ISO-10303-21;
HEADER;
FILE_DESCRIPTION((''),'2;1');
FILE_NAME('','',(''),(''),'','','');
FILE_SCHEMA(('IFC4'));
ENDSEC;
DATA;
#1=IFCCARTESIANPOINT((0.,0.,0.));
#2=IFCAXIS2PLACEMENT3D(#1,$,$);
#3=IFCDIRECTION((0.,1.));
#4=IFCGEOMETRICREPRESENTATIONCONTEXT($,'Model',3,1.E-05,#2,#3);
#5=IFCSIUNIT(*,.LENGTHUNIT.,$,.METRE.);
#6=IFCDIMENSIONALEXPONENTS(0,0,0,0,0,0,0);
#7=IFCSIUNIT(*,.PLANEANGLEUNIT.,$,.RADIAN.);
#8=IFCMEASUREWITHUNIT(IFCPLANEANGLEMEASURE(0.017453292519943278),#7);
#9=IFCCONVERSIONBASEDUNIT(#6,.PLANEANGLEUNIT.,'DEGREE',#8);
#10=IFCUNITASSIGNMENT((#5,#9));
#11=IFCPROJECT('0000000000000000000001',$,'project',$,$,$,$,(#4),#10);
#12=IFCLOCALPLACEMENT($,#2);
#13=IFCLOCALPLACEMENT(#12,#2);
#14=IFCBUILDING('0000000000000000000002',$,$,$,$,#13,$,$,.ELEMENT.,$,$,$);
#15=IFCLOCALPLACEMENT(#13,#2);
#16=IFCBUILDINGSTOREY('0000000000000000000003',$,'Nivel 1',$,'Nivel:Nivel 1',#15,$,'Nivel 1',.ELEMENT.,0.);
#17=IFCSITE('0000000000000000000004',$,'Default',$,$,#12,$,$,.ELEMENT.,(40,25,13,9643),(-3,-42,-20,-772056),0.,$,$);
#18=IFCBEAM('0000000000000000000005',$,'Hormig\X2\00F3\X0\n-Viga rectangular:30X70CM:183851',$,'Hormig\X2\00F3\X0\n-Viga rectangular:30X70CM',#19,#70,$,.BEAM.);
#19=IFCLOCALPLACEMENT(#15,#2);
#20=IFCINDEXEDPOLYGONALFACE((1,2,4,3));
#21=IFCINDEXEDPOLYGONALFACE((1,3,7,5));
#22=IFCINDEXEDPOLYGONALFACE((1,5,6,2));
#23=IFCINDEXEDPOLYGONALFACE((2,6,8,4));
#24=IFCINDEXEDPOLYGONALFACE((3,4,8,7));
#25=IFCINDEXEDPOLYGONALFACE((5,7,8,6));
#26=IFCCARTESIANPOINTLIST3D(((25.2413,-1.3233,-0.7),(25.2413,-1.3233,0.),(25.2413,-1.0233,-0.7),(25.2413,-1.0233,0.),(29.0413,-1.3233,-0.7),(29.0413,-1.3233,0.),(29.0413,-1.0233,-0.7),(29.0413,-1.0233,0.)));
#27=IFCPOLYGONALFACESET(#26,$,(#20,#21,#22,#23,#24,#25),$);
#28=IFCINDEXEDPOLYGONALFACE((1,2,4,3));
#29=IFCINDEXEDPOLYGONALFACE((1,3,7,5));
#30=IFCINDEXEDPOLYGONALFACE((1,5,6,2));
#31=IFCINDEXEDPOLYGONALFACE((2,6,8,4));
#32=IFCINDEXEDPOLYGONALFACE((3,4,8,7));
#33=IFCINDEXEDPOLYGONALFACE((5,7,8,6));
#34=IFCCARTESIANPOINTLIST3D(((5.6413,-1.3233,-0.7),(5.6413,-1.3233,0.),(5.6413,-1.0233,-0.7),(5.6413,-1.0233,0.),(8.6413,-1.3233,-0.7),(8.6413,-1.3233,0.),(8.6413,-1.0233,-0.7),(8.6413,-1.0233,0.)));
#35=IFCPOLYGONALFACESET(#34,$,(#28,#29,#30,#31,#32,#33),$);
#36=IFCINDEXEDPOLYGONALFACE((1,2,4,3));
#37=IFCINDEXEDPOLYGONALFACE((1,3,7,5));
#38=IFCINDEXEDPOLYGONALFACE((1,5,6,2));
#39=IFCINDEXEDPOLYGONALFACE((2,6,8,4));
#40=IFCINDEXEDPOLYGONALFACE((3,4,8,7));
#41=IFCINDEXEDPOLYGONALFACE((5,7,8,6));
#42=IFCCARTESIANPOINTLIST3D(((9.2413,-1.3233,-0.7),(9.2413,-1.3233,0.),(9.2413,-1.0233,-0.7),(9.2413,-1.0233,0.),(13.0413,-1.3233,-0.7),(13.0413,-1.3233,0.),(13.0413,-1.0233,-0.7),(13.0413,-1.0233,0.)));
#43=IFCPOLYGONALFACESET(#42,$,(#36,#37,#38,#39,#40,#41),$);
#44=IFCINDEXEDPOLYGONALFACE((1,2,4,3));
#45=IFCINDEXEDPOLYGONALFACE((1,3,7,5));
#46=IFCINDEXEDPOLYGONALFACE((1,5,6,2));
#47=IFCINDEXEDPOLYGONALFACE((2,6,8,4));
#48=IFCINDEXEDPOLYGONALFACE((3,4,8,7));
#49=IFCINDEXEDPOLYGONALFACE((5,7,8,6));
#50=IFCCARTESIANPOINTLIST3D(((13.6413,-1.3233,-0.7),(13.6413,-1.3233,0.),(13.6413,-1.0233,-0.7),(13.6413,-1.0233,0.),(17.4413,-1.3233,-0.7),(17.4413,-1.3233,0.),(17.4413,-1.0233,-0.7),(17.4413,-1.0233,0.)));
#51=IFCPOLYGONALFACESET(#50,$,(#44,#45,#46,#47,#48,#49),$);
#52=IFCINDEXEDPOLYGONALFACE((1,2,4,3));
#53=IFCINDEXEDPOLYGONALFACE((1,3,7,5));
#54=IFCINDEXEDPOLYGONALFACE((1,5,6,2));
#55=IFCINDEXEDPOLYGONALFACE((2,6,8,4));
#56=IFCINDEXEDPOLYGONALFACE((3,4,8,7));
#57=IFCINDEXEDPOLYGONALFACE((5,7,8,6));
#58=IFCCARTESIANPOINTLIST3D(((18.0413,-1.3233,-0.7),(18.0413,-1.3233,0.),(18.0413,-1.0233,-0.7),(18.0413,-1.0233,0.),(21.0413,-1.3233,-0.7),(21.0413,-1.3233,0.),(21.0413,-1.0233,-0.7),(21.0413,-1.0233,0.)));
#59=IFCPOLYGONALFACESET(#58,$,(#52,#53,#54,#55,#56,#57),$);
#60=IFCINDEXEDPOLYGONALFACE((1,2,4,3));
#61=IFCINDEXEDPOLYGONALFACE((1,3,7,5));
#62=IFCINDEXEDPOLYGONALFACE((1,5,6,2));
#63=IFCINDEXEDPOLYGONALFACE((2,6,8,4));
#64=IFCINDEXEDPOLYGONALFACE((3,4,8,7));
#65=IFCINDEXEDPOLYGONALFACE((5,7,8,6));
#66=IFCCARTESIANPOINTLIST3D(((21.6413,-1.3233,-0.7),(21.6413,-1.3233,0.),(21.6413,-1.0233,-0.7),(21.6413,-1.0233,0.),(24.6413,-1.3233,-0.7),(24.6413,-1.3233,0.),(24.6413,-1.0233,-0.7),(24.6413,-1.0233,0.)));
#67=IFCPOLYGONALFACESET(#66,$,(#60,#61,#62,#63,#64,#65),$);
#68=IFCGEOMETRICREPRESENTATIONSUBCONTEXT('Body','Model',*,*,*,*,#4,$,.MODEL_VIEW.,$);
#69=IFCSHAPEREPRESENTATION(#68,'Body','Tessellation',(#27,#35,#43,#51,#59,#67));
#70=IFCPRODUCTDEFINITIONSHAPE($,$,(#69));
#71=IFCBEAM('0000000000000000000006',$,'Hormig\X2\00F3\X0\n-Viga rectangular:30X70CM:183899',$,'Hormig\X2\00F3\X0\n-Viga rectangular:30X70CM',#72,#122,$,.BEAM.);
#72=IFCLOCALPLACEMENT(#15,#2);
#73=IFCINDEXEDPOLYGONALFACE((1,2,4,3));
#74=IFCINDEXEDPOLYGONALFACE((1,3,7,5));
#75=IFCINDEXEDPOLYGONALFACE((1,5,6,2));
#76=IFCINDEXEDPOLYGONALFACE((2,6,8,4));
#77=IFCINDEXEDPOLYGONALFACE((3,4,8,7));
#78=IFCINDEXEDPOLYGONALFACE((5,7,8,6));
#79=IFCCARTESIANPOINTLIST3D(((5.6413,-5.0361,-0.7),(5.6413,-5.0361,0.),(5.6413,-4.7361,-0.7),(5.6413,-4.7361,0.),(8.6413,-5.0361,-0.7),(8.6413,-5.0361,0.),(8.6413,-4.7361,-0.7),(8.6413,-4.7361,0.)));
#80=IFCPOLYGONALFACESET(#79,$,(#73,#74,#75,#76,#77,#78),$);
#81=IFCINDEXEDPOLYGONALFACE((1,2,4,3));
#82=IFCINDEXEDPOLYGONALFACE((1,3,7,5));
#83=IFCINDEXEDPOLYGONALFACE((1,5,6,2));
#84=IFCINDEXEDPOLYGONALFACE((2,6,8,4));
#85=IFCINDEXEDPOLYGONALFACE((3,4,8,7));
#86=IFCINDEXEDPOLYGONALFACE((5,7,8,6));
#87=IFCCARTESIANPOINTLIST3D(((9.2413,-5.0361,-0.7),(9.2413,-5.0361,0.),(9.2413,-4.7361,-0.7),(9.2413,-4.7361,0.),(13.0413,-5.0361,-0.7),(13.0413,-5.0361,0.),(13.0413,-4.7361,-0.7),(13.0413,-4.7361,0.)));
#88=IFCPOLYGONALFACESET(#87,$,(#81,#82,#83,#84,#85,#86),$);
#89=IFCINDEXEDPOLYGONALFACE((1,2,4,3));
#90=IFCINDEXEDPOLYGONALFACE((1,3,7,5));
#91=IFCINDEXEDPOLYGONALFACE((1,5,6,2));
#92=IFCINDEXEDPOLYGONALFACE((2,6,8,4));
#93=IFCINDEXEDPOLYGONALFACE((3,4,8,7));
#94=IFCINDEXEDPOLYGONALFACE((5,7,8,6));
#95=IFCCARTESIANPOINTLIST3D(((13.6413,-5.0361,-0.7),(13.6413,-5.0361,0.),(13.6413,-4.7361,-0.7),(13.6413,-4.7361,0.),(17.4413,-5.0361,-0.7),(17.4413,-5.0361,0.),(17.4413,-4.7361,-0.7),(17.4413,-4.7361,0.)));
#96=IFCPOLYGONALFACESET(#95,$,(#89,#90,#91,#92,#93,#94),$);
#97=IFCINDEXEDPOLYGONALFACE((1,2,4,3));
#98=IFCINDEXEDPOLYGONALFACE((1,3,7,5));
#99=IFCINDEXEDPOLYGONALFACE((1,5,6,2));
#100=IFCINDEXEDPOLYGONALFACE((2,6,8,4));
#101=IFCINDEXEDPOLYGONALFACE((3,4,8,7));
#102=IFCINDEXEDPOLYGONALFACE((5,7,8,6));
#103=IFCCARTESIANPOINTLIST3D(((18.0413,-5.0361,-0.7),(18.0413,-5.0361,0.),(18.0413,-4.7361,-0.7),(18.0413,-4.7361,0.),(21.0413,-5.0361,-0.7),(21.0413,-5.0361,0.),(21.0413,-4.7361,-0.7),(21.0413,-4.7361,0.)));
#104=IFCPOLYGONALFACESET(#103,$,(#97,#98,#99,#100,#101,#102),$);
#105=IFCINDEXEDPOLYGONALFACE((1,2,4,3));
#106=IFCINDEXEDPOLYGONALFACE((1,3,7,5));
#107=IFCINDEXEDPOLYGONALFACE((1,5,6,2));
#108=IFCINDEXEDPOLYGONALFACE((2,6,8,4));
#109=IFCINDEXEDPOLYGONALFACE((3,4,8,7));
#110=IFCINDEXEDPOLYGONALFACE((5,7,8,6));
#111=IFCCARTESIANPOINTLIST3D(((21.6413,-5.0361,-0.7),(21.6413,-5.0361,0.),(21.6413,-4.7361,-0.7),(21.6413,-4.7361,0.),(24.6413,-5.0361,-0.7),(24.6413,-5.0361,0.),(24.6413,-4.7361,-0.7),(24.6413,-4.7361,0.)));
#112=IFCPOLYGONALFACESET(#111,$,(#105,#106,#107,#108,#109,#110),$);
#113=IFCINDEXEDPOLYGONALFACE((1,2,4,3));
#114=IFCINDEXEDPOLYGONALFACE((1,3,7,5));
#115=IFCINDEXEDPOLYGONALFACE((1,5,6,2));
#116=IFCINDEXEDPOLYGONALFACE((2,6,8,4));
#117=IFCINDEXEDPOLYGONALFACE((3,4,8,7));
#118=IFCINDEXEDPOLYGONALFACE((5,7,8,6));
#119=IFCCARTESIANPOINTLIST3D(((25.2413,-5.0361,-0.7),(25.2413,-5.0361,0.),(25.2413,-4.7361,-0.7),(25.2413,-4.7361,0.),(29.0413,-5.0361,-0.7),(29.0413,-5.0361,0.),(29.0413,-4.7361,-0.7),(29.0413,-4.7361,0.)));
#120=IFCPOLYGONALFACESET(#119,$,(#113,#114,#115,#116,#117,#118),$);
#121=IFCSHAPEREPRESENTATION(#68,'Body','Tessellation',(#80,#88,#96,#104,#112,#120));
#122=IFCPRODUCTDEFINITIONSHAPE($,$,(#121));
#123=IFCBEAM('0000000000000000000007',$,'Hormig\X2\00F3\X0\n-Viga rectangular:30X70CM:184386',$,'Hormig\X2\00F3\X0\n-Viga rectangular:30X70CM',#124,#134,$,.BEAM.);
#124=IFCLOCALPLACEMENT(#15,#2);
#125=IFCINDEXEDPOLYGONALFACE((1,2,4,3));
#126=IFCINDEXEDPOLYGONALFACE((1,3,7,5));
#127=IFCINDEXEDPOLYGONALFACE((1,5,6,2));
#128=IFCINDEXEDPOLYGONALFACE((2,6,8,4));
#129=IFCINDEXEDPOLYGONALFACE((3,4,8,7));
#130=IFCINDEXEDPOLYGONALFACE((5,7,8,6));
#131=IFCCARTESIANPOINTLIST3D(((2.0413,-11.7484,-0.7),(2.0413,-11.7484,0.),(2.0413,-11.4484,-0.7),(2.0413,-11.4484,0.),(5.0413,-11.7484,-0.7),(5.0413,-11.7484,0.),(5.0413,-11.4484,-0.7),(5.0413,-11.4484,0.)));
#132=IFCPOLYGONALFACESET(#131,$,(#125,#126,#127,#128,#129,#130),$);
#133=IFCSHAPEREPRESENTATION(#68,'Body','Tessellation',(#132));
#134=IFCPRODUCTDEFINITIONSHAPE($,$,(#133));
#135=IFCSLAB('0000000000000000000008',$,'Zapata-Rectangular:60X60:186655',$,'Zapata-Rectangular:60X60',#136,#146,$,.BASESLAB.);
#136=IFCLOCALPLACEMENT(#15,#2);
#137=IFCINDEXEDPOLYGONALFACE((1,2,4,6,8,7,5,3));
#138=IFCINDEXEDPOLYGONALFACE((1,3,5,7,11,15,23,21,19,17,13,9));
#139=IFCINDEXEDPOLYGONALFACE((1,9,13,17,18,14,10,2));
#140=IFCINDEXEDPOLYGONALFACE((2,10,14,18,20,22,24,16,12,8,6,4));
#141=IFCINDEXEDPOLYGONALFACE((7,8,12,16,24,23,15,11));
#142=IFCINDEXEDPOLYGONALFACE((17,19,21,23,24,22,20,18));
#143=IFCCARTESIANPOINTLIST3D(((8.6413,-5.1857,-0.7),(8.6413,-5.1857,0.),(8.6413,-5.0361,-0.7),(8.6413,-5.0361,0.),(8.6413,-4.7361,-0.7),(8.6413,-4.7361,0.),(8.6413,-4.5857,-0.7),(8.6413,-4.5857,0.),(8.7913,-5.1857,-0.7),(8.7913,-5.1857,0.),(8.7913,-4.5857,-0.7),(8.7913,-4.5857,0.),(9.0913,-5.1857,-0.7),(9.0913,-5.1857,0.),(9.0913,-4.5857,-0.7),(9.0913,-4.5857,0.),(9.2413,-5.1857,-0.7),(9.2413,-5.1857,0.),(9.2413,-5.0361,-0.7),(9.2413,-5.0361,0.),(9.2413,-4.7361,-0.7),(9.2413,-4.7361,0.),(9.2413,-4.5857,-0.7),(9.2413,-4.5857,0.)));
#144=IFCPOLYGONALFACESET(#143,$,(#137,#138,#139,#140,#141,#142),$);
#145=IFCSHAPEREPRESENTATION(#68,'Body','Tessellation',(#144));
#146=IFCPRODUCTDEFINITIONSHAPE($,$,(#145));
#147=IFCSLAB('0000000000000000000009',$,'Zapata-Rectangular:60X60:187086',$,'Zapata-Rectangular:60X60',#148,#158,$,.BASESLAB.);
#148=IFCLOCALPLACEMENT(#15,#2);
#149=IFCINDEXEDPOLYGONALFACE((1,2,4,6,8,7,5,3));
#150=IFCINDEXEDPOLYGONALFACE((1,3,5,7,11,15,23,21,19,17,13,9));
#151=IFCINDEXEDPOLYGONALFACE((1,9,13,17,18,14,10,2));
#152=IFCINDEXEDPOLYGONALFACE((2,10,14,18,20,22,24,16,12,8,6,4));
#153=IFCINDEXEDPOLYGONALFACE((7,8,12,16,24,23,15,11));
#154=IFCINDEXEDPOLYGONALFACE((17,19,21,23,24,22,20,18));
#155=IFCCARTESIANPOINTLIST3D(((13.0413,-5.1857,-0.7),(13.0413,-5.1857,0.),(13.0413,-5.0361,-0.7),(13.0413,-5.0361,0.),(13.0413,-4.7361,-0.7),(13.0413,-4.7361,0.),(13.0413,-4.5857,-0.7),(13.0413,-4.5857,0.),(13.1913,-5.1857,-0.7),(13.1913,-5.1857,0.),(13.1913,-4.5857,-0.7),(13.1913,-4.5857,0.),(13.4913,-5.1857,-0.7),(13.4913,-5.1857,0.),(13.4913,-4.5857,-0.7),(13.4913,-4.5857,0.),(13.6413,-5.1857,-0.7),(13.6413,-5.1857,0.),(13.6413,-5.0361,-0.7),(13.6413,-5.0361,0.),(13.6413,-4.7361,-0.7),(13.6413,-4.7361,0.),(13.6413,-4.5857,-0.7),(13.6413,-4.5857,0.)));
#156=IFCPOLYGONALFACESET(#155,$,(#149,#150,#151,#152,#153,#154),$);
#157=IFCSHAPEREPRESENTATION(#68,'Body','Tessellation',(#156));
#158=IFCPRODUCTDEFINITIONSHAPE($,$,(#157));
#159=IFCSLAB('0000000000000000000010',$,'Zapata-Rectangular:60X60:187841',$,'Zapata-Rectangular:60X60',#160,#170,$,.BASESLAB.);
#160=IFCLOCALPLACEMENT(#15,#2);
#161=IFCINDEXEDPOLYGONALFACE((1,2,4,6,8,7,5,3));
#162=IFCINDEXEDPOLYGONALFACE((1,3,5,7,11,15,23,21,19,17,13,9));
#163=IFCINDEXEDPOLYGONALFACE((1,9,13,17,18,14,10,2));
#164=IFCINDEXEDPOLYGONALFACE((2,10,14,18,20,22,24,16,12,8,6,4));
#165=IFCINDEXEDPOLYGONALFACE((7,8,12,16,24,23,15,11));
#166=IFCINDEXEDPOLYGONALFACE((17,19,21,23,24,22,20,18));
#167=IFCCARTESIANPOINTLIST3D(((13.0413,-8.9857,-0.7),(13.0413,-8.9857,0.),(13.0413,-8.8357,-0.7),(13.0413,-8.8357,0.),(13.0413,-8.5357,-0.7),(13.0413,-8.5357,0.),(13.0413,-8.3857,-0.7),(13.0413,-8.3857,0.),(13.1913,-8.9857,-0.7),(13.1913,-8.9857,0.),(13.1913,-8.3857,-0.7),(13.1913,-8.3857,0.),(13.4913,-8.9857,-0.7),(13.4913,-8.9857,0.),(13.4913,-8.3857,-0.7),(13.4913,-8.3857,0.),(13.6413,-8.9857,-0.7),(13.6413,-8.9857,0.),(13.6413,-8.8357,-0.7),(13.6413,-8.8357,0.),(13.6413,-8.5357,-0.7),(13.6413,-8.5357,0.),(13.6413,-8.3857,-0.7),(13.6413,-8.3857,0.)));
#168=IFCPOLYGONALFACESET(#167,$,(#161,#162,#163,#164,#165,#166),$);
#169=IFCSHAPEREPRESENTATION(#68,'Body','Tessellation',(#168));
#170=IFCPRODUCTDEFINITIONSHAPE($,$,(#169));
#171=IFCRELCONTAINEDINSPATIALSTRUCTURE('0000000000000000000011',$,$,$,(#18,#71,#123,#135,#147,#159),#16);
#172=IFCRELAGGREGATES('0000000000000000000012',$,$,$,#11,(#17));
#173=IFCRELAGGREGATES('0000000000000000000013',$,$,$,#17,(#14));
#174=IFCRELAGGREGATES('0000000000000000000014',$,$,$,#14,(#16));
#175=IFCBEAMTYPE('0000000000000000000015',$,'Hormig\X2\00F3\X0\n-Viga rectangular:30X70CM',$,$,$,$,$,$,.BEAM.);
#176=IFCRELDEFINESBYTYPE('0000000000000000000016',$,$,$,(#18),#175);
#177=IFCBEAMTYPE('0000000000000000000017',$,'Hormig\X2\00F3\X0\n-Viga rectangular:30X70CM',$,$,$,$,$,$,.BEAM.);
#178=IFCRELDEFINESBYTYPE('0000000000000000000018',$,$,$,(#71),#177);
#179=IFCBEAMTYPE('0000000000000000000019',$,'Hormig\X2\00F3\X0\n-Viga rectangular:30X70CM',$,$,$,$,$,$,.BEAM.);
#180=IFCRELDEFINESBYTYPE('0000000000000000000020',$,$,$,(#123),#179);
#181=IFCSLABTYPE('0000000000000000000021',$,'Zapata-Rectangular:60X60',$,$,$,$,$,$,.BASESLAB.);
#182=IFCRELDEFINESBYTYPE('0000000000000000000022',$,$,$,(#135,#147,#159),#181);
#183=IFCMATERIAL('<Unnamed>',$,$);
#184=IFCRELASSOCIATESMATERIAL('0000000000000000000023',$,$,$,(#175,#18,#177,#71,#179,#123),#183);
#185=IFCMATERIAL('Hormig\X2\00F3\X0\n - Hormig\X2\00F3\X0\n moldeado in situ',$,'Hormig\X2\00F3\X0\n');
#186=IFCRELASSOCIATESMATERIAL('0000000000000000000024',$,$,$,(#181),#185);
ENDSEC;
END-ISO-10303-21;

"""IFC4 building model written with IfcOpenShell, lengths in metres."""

from ifc_helpers import new_model, entity, si_unit, converted_unit, direction, frame, origin, place, context, subcontext, project, spatial, indexed_curve, outline, extrude, source, transform, mapped, material, type_object, type_shapes, element, save


model = new_model("IFC4")

# Units and contexts
model_context = context("Model", 3, precision=1e-05, world=origin(), true_north=direction((0.0, 1.0)))
body_context = subcontext(model_context, "Body", "Model", "MODEL_VIEW")
ifc_project = project(units=[si_unit("LENGTHUNIT", "METRE"), converted_unit("PLANEANGLEUNIT", "DEGREE", entity("IfcPlaneAngleMeasure", 0.017453292519943278), si_unit("PLANEANGLEUNIT", "RADIAN"), dimensions=[0, 0, 0, 0, 0, 0, 0])], contexts=[model_context])

# Site, building, storey
site_placement = place(None, origin())
site = spatial("IfcSite", under=ifc_project, at=site_placement, Name="Default", CompositionType="ELEMENT", RefLatitude=(40, 25, 13, 9643), RefLongitude=(-3, -42, -20, -772056), RefElevation=0.0)
building_placement = place(site_placement, origin())
building = spatial("IfcBuilding", under=site, at=building_placement, CompositionType="ELEMENT")
storey_placement = place(building_placement, origin())
storey = spatial("IfcBuildingStorey", under=building, at=storey_placement, Name="Nivel 1", ObjectType="Nivel:Nivel 1", LongName="Nivel 1", CompositionType="ELEMENT", Elevation=0.0)

# Beams
ifc_material_1 = material(Name="<Unnamed>")
beam_type_1 = type_object("IfcBeamType", Name="Hormigón-Viga rectangular:30X70CM", PredefinedType="BEAM", material=ifc_material_1)
shared_shape_1 = source(origin(), body_context, "Body", "SweptSolid", [
    extrude(outline(indexed_curve([(-0.35, -0.15), (0.35, -0.15), (0.35, 0.15), (-0.35, 0.15), (-0.35, -0.15)], self_intersect=False)), frame((29.0413, -1.1733, -0.35), z_axis=(-1.0, 0.0, 0.0), x_axis=(0.0, 0.0, -1.0)), (0.0, 0.0, 1.0), 3.8),
    extrude(outline(indexed_curve([(-0.35, -0.15), (0.35, -0.15), (0.35, 0.15), (-0.35, 0.15), (-0.35, -0.15)], self_intersect=False)), frame((8.6413, -1.1733, -0.35), z_axis=(-1.0, 0.0, 0.0), x_axis=(0.0, 0.0, -1.0)), (0.0, 0.0, 1.0), 3.0),
    extrude(outline(indexed_curve([(-0.35, -0.15), (0.35, -0.15), (0.35, 0.15), (-0.35, 0.15), (-0.35, -0.15)], self_intersect=False)), frame((13.0413, -1.1733, -0.35), z_axis=(-1.0, 0.0, 0.0), x_axis=(0.0, 0.0, -1.0)), (0.0, 0.0, 1.0), 3.8),
    extrude(outline(indexed_curve([(-0.35, -0.15), (0.35, -0.15), (0.35, 0.15), (-0.35, 0.15), (-0.35, -0.15)], self_intersect=False)), frame((17.4413, -1.1733, -0.35), z_axis=(-1.0, 0.0, 0.0), x_axis=(0.0, 0.0, -1.0)), (0.0, 0.0, 1.0), 3.8),
    extrude(outline(indexed_curve([(-0.35, -0.15), (0.35, -0.15), (0.35, 0.15), (-0.35, 0.15), (-0.35, -0.15)], self_intersect=False)), frame((21.0413, -1.1733, -0.35), z_axis=(-1.0, 0.0, 0.0), x_axis=(0.0, 0.0, -1.0)), (0.0, 0.0, 1.0), 3.0),
    extrude(outline(indexed_curve([(-0.35, -0.15), (0.35, -0.15), (0.35, 0.15), (-0.35, 0.15), (-0.35, -0.15)], self_intersect=False)), frame((24.6413, -1.1733, -0.35), z_axis=(-1.0, 0.0, 0.0), x_axis=(0.0, 0.0, -1.0)), (0.0, 0.0, 1.0), 3.0),
])
type_shapes(beam_type_1, [shared_shape_1])
beam_1_placement = place(storey_placement, origin())
element("IfcBeam", 1, at=beam_1_placement, inside=storey, type_object=beam_type_1, material=ifc_material_1, Name="Hormigón-Viga rectangular:30X70CM:183851", ObjectType="Hormigón-Viga rectangular:30X70CM", PredefinedType="BEAM", context=body_context, shape_type="MappedRepresentation", body=[
    mapped(shared_shape_1, transform((0.0, 0.0, 0.0), scale=1.0)),
])
beam_type_2 = type_object("IfcBeamType", Name="Hormigón-Viga rectangular:30X70CM", PredefinedType="BEAM", material=ifc_material_1)
shared_shape_2 = source(origin(), body_context, "Body", "SweptSolid", [
    extrude(outline(indexed_curve([(-0.35, -0.15), (0.35, -0.15), (0.35, 0.15), (-0.35, 0.15), (-0.35, -0.15)], self_intersect=False)), frame((5.6413, -4.8861, -0.35), z_axis=(1.0, 0.0, 0.0), x_axis=(0.0, 0.0, -1.0)), (0.0, 0.0, 1.0), 3.0),
    extrude(outline(indexed_curve([(-0.35, -0.15), (0.35, -0.15), (0.35, 0.15), (-0.35, 0.15), (-0.35, -0.15)], self_intersect=False)), frame((9.2413, -4.8861, -0.35), z_axis=(1.0, 0.0, 0.0), x_axis=(0.0, 0.0, -1.0)), (0.0, 0.0, 1.0), 3.8),
    extrude(outline(indexed_curve([(-0.35, -0.15), (0.35, -0.15), (0.35, 0.15), (-0.35, 0.15), (-0.35, -0.15)], self_intersect=False)), frame((13.6413, -4.8861, -0.35), z_axis=(1.0, 0.0, 0.0), x_axis=(0.0, 0.0, -1.0)), (0.0, 0.0, 1.0), 3.8),
    extrude(outline(indexed_curve([(-0.35, -0.15), (0.35, -0.15), (0.35, 0.15), (-0.35, 0.15), (-0.35, -0.15)], self_intersect=False)), frame((18.0413, -4.8861, -0.35), z_axis=(1.0, 0.0, 0.0), x_axis=(0.0, 0.0, -1.0)), (0.0, 0.0, 1.0), 3.0),
    extrude(outline(indexed_curve([(-0.35, -0.15), (0.35, -0.15), (0.35, 0.15), (-0.35, 0.15), (-0.35, -0.15)], self_intersect=False)), frame((21.6413, -4.8861, -0.35), z_axis=(1.0, 0.0, 0.0), x_axis=(0.0, 0.0, -1.0)), (0.0, 0.0, 1.0), 3.0),
    extrude(outline(indexed_curve([(-0.35, -0.15), (0.35, -0.15), (0.35, 0.15), (-0.35, 0.15), (-0.35, -0.15)], self_intersect=False)), frame((25.2413, -4.8861, -0.35), z_axis=(1.0, 0.0, 0.0), x_axis=(0.0, 0.0, -1.0)), (0.0, 0.0, 1.0), 3.8),
])
type_shapes(beam_type_2, [shared_shape_2])
beam_2_placement = place(storey_placement, origin())
element("IfcBeam", 2, at=beam_2_placement, inside=storey, type_object=beam_type_2, material=ifc_material_1, Name="Hormigón-Viga rectangular:30X70CM:183899", ObjectType="Hormigón-Viga rectangular:30X70CM", PredefinedType="BEAM", context=body_context, shape_type="MappedRepresentation", body=[
    mapped(shared_shape_2, transform((0.0, 0.0, 0.0), scale=1.0)),
])
beam_type_3 = type_object("IfcBeamType", Name="Hormigón-Viga rectangular:30X70CM", PredefinedType="BEAM", material=ifc_material_1)
shared_shape_3 = source(origin(), body_context, "Body", "SweptSolid", [
    extrude(outline(indexed_curve([(-0.35, -0.15), (0.35, -0.15), (0.35, 0.15), (-0.35, 0.15), (-0.35, -0.15)], self_intersect=False)), frame((2.0413, -11.5984, -0.35), z_axis=(1.0, 0.0, 0.0), x_axis=(0.0, 0.0, -1.0)), (0.0, 0.0, 1.0), 3.0),
])
type_shapes(beam_type_3, [shared_shape_3])
beam_3_placement = place(storey_placement, origin())
element("IfcBeam", 3, at=beam_3_placement, inside=storey, type_object=beam_type_3, material=ifc_material_1, Name="Hormigón-Viga rectangular:30X70CM:184386", ObjectType="Hormigón-Viga rectangular:30X70CM", PredefinedType="BEAM", context=body_context, shape_type="MappedRepresentation", body=[
    mapped(shared_shape_3, transform((0.0, 0.0, 0.0), scale=1.0)),
])

# Slabs
ifc_material_2 = material(Name="Hormigón - Hormigón moldeado in situ", Category="Hormigón")
slab_type = type_object("IfcSlabType", Name="Zapata-Rectangular:60X60", PredefinedType="BASESLAB", material=ifc_material_2)
slab_1_placement = place(storey_placement, origin())
element("IfcSlab", 4, at=slab_1_placement, inside=storey, type_object=slab_type, Name="Zapata-Rectangular:60X60:186655", ObjectType="Zapata-Rectangular:60X60", PredefinedType="BASESLAB", context=body_context, shape_type="SweptSolid", body=[
    extrude(outline(indexed_curve([(-0.3, -0.3001), (-0.15, -0.3001), (0.15, -0.3001), (0.3, -0.3001), (0.3, -0.1498), (0.3, 0.1502), (0.3, 0.2999), (0.15, 0.2999), (-0.15, 0.2999), (-0.3, 0.2999), (-0.3, 0.1502), (-0.3, -0.1498), (-0.3, -0.3001)], self_intersect=False)), frame((8.9413, -4.8858, -0.7), z_axis=(0.0, 0.0, 1.0), x_axis=(-1.0, 0.0, 0.0)), (0.0, 0.0, 1.0), 0.7),
])
slab_2_placement = place(storey_placement, origin())
element("IfcSlab", 5, at=slab_2_placement, inside=storey, type_object=slab_type, Name="Zapata-Rectangular:60X60:187086", ObjectType="Zapata-Rectangular:60X60", PredefinedType="BASESLAB", context=body_context, shape_type="SweptSolid", body=[
    extrude(outline(indexed_curve([(-0.3, -0.3001), (-0.15, -0.3001), (0.15, -0.3001), (0.3, -0.3001), (0.3, -0.1498), (0.3, 0.1502), (0.3, 0.2999), (0.15, 0.2999), (-0.15, 0.2999), (-0.3, 0.2999), (-0.3, 0.1502), (-0.3, -0.1498), (-0.3, -0.3001)], self_intersect=False)), frame((13.3413, -4.8858, -0.7), z_axis=(0.0, 0.0, 1.0), x_axis=(-1.0, 0.0, 0.0)), (0.0, 0.0, 1.0), 0.7),
])
slab_3_placement = place(storey_placement, origin())
element("IfcSlab", 6, at=slab_3_placement, inside=storey, type_object=slab_type, Name="Zapata-Rectangular:60X60:187841", ObjectType="Zapata-Rectangular:60X60", PredefinedType="BASESLAB", context=body_context, shape_type="SweptSolid", body=[
    extrude(outline(indexed_curve([(-0.3, -0.3), (-0.15, -0.3), (0.15, -0.3), (0.3, -0.3), (0.3, -0.15), (0.3, 0.15), (0.3, 0.3), (0.15, 0.3), (-0.15, 0.3), (-0.3, 0.3), (-0.3, 0.15), (-0.3, -0.15), (-0.3, -0.3)], self_intersect=False)), frame((13.3413, -8.6857, -0.7), z_axis=(0.0, 0.0, 1.0), x_axis=(-1.0, 0.0, 0.0)), (0.0, 0.0, 1.0), 0.7),
])

save(model, "model.ifc")
